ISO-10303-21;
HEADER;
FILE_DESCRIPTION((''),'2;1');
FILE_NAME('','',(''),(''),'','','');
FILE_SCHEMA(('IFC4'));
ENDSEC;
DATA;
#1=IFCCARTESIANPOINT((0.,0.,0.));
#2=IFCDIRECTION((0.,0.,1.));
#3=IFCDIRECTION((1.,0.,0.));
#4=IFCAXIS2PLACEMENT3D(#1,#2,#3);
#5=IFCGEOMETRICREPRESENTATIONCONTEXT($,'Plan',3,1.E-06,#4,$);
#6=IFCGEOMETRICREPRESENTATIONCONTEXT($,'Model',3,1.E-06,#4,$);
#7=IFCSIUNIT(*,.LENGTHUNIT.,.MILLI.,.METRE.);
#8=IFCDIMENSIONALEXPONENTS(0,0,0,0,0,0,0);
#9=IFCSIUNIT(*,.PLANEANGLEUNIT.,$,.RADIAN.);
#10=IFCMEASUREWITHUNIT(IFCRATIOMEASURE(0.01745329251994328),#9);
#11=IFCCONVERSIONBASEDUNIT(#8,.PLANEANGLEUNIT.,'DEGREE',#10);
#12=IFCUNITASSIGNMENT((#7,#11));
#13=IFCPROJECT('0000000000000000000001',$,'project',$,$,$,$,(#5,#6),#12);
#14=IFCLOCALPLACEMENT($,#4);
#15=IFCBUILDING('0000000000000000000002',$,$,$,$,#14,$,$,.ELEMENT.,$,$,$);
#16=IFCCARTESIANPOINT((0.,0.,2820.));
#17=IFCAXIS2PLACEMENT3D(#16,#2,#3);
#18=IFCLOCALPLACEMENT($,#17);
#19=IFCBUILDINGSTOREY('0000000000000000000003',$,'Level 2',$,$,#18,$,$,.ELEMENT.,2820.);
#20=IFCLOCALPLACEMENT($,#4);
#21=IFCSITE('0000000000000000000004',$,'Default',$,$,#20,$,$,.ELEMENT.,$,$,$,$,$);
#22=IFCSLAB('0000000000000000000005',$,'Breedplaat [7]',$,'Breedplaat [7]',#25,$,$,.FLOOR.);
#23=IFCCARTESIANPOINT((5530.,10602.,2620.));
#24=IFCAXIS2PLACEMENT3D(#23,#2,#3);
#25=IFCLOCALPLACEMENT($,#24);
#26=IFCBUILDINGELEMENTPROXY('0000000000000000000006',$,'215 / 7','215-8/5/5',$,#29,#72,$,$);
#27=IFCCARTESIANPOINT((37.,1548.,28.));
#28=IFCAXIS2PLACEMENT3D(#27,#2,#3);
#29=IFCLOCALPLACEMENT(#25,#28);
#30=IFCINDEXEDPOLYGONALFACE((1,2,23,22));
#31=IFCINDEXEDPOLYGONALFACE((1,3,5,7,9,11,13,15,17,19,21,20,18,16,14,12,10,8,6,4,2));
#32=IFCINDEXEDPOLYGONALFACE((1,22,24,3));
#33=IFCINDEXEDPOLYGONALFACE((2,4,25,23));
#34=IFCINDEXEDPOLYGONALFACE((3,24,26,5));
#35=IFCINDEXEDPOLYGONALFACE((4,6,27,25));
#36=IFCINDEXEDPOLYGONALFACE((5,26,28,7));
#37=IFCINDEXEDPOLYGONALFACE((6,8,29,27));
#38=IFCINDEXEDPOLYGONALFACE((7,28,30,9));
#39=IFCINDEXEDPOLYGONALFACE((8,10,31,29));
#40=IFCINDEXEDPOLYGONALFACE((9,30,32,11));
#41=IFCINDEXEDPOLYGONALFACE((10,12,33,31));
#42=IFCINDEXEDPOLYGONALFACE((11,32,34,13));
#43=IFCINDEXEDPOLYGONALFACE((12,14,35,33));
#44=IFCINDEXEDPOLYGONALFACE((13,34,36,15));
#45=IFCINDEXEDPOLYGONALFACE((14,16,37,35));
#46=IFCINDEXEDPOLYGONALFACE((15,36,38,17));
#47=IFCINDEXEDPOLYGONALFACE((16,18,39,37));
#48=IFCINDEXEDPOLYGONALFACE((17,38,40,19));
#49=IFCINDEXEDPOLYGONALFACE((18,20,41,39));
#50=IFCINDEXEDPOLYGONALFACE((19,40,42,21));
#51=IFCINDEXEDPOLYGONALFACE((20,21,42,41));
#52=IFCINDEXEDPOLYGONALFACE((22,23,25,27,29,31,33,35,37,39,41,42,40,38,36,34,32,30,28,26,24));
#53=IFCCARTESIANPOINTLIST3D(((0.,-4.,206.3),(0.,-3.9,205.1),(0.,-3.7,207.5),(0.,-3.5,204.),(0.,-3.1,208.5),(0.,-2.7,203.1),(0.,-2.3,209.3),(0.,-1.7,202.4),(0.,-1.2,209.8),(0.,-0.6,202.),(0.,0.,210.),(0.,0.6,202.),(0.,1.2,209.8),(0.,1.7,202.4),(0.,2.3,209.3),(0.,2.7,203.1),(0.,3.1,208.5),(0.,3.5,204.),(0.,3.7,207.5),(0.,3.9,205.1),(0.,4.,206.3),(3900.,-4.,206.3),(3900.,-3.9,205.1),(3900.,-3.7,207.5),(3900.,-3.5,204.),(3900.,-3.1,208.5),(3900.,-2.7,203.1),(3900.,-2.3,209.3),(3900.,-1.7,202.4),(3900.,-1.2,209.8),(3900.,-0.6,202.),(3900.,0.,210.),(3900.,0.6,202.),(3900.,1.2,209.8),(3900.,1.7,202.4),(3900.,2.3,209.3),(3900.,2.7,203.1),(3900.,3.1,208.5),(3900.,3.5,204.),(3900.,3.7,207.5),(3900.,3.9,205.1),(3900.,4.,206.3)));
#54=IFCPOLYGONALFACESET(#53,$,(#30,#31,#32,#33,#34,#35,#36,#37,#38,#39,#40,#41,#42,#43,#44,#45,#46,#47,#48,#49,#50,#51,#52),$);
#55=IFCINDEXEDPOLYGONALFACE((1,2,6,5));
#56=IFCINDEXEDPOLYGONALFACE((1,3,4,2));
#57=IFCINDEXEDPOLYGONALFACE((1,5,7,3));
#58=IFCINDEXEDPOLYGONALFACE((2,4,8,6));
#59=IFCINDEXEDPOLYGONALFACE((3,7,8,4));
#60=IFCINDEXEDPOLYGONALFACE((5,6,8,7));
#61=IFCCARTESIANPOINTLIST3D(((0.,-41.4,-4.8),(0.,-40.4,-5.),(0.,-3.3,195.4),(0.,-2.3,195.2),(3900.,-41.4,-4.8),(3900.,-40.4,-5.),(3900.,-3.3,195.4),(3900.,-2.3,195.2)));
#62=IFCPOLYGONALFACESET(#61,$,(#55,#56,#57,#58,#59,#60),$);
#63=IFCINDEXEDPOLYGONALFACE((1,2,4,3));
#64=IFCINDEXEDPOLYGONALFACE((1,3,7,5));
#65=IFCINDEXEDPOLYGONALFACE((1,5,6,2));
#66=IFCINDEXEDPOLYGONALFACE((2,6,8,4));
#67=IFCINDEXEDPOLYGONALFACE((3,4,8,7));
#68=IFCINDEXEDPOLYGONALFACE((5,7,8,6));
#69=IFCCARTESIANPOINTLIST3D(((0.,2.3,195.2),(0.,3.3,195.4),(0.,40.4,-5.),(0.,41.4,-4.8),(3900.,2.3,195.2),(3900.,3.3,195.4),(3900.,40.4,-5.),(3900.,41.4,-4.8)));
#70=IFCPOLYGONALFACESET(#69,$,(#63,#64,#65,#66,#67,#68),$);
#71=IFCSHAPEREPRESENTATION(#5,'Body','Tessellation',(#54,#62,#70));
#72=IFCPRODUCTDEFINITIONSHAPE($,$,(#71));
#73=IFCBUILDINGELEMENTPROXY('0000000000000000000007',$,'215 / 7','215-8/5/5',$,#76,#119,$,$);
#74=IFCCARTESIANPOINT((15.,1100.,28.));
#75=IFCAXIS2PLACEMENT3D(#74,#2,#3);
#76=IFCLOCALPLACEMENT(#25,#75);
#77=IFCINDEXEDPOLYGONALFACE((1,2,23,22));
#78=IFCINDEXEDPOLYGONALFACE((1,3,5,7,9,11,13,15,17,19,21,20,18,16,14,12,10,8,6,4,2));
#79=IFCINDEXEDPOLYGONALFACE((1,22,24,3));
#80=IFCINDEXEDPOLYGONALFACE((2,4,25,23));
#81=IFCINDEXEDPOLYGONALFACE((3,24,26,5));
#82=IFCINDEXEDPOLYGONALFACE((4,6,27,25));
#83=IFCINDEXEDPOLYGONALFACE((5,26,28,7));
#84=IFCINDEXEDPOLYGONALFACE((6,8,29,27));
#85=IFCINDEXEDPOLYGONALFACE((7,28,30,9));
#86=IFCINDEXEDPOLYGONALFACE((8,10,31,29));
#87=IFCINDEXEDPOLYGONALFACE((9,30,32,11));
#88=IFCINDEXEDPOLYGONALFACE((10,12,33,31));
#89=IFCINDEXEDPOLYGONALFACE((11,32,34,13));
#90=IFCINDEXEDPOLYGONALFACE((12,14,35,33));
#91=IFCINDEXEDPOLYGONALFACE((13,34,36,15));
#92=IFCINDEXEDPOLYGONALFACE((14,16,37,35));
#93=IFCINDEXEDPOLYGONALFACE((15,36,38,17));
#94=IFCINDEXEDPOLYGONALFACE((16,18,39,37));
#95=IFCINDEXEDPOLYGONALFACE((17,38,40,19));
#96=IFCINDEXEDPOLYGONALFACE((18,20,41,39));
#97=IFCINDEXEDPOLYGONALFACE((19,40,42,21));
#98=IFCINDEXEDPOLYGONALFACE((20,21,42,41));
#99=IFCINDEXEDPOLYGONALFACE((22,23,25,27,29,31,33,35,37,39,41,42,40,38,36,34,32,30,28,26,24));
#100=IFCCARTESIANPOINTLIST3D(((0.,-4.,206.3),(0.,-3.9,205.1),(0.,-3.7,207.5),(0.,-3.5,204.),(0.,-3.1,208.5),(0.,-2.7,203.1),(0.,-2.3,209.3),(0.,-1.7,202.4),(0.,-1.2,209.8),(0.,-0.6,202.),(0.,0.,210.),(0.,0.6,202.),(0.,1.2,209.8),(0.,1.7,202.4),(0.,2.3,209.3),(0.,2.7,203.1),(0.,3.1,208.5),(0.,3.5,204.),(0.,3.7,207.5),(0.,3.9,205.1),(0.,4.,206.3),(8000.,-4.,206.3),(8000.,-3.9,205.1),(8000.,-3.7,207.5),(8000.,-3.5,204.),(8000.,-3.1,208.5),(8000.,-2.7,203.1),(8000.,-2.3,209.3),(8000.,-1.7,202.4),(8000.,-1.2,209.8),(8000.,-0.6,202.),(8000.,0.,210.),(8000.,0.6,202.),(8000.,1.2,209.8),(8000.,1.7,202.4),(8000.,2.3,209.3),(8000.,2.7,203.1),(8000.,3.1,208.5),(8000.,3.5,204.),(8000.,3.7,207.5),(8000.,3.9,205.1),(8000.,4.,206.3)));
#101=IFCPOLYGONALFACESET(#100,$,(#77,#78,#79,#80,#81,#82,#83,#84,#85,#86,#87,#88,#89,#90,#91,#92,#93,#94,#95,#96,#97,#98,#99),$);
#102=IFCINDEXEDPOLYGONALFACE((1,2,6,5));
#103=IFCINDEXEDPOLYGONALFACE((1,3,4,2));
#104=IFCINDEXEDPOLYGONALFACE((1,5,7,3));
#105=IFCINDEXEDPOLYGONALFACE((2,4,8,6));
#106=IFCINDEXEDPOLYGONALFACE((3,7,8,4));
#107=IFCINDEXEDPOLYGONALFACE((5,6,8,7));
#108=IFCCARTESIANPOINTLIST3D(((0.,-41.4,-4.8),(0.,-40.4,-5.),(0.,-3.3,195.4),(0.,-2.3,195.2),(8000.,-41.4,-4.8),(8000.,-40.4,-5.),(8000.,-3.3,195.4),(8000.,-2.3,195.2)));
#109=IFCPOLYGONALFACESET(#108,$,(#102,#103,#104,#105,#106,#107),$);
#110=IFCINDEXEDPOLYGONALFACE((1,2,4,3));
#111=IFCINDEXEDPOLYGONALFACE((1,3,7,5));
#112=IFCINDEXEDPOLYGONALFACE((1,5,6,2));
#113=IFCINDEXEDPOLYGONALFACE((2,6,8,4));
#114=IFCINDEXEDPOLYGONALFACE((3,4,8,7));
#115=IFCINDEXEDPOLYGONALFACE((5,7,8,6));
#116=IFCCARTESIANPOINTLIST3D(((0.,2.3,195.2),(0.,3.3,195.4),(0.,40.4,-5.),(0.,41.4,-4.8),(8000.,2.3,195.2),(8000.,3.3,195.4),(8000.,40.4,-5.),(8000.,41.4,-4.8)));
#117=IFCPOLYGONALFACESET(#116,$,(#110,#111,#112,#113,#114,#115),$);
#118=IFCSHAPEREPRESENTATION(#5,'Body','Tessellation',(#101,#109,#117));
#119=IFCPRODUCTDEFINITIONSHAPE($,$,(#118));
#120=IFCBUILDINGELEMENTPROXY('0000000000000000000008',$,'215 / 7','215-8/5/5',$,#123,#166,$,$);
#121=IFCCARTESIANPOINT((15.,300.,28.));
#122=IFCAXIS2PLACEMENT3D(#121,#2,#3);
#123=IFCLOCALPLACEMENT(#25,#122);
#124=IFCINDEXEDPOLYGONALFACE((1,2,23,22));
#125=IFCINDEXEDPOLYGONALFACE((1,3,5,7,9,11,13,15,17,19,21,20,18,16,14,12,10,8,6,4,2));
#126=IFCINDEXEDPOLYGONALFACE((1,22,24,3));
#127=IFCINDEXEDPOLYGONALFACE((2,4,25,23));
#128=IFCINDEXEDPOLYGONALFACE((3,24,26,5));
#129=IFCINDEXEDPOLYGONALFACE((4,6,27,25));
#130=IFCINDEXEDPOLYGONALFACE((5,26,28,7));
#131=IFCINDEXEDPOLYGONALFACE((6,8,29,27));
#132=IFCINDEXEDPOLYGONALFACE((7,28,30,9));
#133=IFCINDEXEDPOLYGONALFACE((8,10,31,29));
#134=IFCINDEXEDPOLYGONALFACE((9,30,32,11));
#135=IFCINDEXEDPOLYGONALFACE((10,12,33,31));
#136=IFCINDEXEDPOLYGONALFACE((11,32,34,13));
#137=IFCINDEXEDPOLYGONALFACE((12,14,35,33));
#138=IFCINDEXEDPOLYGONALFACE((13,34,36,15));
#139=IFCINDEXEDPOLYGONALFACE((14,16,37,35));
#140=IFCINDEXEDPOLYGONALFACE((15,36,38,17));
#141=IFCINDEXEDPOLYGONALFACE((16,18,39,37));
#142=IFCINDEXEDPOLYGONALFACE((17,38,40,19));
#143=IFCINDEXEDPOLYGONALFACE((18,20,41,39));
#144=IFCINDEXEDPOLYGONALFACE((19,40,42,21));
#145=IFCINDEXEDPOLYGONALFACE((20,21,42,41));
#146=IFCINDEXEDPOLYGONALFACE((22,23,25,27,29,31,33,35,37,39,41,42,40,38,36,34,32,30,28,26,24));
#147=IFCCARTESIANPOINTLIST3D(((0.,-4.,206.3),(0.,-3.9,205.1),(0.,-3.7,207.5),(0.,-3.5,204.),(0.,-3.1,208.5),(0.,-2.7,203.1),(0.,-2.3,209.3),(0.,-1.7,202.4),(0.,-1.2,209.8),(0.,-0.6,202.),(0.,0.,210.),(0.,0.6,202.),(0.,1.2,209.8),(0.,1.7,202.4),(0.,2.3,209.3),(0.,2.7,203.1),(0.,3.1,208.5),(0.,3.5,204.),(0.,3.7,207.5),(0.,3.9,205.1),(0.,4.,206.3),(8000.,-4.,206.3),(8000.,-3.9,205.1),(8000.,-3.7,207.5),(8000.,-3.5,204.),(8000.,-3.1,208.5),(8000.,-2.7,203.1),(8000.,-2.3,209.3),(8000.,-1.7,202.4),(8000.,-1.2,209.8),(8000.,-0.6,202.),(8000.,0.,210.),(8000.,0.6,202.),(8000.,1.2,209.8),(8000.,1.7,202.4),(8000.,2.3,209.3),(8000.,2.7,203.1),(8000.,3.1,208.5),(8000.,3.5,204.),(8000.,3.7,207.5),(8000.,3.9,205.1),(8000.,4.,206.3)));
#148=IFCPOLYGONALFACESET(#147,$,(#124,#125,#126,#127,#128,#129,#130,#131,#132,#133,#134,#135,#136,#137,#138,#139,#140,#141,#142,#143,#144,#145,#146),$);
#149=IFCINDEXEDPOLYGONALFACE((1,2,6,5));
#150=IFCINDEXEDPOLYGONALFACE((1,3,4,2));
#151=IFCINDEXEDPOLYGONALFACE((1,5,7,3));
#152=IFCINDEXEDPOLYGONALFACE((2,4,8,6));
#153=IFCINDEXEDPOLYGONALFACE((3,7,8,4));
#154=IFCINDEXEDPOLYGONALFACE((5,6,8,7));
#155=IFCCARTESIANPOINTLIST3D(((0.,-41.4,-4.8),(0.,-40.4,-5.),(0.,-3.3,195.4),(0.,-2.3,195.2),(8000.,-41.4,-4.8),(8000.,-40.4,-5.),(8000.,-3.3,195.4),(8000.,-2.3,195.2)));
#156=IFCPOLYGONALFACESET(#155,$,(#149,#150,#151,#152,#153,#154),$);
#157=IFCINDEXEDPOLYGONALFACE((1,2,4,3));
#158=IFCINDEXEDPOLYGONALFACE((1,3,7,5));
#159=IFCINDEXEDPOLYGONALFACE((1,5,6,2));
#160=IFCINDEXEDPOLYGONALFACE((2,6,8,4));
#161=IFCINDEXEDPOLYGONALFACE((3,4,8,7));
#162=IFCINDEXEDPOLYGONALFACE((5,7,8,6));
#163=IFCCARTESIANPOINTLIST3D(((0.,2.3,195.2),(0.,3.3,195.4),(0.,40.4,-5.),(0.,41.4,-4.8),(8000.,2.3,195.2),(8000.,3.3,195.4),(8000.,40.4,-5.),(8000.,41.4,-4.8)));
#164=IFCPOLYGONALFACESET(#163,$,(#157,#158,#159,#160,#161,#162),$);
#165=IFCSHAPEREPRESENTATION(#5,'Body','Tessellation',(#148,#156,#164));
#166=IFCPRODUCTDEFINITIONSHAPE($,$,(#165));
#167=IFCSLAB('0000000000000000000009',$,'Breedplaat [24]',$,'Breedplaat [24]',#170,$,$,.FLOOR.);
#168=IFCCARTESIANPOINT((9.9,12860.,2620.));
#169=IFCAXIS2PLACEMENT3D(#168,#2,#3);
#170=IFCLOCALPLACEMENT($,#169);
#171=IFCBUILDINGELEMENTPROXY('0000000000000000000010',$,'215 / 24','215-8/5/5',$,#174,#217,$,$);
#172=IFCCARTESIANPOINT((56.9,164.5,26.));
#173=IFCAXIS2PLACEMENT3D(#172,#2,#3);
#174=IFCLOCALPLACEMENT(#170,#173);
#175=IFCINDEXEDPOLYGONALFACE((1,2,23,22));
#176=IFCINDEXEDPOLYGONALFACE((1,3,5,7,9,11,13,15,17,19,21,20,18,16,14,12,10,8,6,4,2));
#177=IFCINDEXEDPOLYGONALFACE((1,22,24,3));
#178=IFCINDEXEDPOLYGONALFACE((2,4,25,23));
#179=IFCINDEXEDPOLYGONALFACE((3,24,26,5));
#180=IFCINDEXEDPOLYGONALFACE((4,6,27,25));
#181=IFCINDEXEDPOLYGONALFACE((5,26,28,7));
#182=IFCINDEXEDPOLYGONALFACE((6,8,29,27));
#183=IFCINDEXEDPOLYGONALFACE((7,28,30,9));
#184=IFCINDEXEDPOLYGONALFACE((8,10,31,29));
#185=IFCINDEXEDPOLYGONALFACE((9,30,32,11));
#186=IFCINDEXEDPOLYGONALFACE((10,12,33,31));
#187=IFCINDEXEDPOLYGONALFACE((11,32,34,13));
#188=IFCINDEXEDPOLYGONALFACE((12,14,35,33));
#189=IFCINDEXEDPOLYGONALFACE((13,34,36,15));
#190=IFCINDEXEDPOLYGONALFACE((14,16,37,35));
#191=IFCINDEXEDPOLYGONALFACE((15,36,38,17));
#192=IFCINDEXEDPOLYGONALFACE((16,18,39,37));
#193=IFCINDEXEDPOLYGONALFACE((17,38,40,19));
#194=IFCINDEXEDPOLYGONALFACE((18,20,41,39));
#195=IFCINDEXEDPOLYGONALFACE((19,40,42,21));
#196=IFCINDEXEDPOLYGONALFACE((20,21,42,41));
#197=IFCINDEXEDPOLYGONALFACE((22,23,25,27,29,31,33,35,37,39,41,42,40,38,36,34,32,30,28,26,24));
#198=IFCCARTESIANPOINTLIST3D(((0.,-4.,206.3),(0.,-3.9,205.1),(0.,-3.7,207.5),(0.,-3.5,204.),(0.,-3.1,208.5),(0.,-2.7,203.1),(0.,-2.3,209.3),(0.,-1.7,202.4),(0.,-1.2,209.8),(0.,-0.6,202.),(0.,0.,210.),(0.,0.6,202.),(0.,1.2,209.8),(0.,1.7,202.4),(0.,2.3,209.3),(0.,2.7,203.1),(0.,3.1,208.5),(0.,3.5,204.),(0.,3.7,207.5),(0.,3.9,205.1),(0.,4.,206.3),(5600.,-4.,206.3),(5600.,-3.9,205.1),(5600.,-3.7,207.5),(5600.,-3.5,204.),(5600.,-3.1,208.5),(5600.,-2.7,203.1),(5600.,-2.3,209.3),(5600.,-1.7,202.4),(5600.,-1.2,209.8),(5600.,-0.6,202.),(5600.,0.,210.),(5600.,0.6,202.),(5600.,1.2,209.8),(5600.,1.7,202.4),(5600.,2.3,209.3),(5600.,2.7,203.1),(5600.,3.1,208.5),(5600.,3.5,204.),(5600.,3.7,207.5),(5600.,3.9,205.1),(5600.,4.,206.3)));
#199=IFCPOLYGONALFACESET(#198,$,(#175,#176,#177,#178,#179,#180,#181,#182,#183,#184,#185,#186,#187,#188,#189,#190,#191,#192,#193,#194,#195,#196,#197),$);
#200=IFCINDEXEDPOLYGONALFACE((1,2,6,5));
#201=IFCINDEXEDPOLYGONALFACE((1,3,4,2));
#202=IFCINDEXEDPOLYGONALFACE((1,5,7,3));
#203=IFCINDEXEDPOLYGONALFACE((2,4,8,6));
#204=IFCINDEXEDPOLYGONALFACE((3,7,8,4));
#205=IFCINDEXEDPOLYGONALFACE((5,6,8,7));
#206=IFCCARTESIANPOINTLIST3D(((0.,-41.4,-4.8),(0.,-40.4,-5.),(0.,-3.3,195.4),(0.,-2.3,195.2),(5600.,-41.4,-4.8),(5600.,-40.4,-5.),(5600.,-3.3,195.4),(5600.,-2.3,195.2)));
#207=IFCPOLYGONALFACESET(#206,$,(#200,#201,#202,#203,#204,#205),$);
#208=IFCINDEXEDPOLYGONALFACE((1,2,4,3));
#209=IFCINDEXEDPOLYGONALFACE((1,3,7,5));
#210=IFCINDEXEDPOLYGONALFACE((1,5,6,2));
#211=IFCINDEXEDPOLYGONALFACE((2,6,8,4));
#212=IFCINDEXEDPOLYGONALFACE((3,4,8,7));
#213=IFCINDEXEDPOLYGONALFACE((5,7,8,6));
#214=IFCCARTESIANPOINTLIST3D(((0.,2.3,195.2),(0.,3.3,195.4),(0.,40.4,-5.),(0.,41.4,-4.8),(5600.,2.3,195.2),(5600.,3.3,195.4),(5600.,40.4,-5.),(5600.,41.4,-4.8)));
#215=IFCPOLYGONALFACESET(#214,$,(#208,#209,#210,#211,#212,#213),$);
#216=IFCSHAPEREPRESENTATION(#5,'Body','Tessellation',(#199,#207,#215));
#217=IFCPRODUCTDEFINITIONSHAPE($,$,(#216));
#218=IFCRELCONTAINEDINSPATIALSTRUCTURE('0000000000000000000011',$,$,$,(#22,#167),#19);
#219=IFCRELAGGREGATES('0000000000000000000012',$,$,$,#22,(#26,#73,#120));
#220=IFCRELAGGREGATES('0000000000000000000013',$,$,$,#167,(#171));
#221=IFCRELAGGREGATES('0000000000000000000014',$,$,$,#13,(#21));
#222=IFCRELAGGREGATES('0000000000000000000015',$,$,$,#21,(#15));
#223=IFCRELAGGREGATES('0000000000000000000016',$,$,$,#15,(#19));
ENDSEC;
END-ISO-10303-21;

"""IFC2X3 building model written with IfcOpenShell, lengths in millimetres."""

from ifc_helpers import new_model, entity, si_unit, converted_unit, frame, origin_with_axes, origin_2d_with_axis, place, context, project, spatial, rectangle, circle, extrude, element, aggregate, save


model = new_model("IFC2X3")

# Units and contexts
plan_context = context("Plan", 3, precision=1e-06, world=origin_with_axes())
model_context = context("Model", 3, precision=1e-06, world=origin_with_axes())
ifc_project = project(units=[si_unit("LENGTHUNIT", "METRE", prefix="MILLI"), converted_unit("PLANEANGLEUNIT", "DEGREE", entity("IfcRatioMeasure", 0.01745329251994328), si_unit("PLANEANGLEUNIT", "RADIAN"), dimensions=[0, 0, 0, 0, 0, 0, 0])], contexts=[plan_context, model_context])

# Site, building, storey
site_placement = place(None, origin_with_axes())
site = spatial("IfcSite", under=ifc_project, at=site_placement, Name="Default", CompositionType="ELEMENT")
building_placement = place(None, origin_with_axes())
building = spatial("IfcBuilding", under=site, at=building_placement, CompositionType="ELEMENT")
storey_placement = place(None, frame((0.0, 0.0, 2820.0), z_axis=(0.0, 0.0, 1.0), x_axis=(1.0, 0.0, 0.0)))
storey = spatial("IfcBuildingStorey", under=building, at=storey_placement, Name="Level 2", CompositionType="ELEMENT", Elevation=2820.0)

# Slab, building element proxies
slab_1_placement = place(None, frame((5530.0, 10602.0, 2620.0), z_axis=(0.0, 0.0, 1.0), x_axis=(1.0, 0.0, 0.0)))
slab_1 = element("IfcSlab", 1, at=slab_1_placement, inside=storey, Name="Breedplaat [7]", ObjectType="Breedplaat [7]", PredefinedType="FLOOR")
proxy_1_placement = place(slab_1_placement, frame((37.0, 1548.0, 28.0), z_axis=(0.0, 0.0, 1.0), x_axis=(1.0, 0.0, 0.0)))
proxy_1 = element("IfcBuildingElementProxy", 2, at=proxy_1_placement, Name="215 / 7", Description="215-8/5/5", context=plan_context, shape_type="SweptSolid", body=[
    extrude(circle(Radius=4.0, at=origin_2d_with_axis()), frame((0.0, 0.0, 206.0), z_axis=(1.0, 0.0, 0.0), x_axis=(0.0, 0.0, 1.0)), (0.0, 0.0, 1.0), 3900.0),
    extrude(rectangle(XDim=203.8, YDim=1.0, at=origin_2d_with_axis()), frame((0.0, -21.9, 95.2), z_axis=(1.0, 0.0, 0.0), x_axis=(0.0, 0.187112, 0.982339)), (0.0, 0.0, 1.0), 3900.0),
    extrude(rectangle(XDim=203.8, YDim=1.0, at=origin_2d_with_axis()), frame((0.0, 21.9, 95.2), z_axis=(1.0, 0.0, 0.0), x_axis=(0.0, -0.187112, 0.982339)), (0.0, 0.0, 1.0), 3900.0),
])
proxy_2_placement = place(slab_1_placement, frame((15.0, 1100.0, 28.0), z_axis=(0.0, 0.0, 1.0), x_axis=(1.0, 0.0, 0.0)))
proxy_2 = element("IfcBuildingElementProxy", 3, at=proxy_2_placement, Name="215 / 7", Description="215-8/5/5", context=plan_context, shape_type="SweptSolid", body=[
    extrude(circle(Radius=4.0, at=origin_2d_with_axis()), frame((0.0, 0.0, 206.0), z_axis=(1.0, 0.0, 0.0), x_axis=(0.0, 0.0, 1.0)), (0.0, 0.0, 1.0), 8000.0),
    extrude(rectangle(XDim=203.8, YDim=1.0, at=origin_2d_with_axis()), frame((0.0, -21.9, 95.2), z_axis=(1.0, 0.0, 0.0), x_axis=(0.0, 0.187112, 0.982339)), (0.0, 0.0, 1.0), 8000.0),
    extrude(rectangle(XDim=203.8, YDim=1.0, at=origin_2d_with_axis()), frame((0.0, 21.9, 95.2), z_axis=(1.0, 0.0, 0.0), x_axis=(0.0, -0.187112, 0.982339)), (0.0, 0.0, 1.0), 8000.0),
])
proxy_3_placement = place(slab_1_placement, frame((15.0, 300.0, 28.0), z_axis=(0.0, 0.0, 1.0), x_axis=(1.0, 0.0, 0.0)))
proxy_3 = element("IfcBuildingElementProxy", 4, at=proxy_3_placement, Name="215 / 7", Description="215-8/5/5", context=plan_context, shape_type="SweptSolid", body=[
    extrude(circle(Radius=4.0, at=origin_2d_with_axis()), frame((0.0, 0.0, 206.0), z_axis=(1.0, 0.0, 0.0), x_axis=(0.0, 0.0, 1.0)), (0.0, 0.0, 1.0), 8000.0),
    extrude(rectangle(XDim=203.8, YDim=1.0, at=origin_2d_with_axis()), frame((0.0, -21.9, 95.2), z_axis=(1.0, 0.0, 0.0), x_axis=(0.0, 0.187112, 0.982339)), (0.0, 0.0, 1.0), 8000.0),
    extrude(rectangle(XDim=203.8, YDim=1.0, at=origin_2d_with_axis()), frame((0.0, 21.9, 95.2), z_axis=(1.0, 0.0, 0.0), x_axis=(0.0, -0.187112, 0.982339)), (0.0, 0.0, 1.0), 8000.0),
])
aggregate(slab_1, [proxy_1, proxy_2, proxy_3])

# Slab, building element proxy
slab_2_placement = place(None, frame((9.9, 12860.0, 2620.0), z_axis=(0.0, 0.0, 1.0), x_axis=(1.0, 0.0, 0.0)))
slab_2 = element("IfcSlab", 5, at=slab_2_placement, inside=storey, Name="Breedplaat [24]", ObjectType="Breedplaat [24]", PredefinedType="FLOOR")
proxy_4_placement = place(slab_2_placement, frame((56.9, 164.5, 26.0), z_axis=(0.0, 0.0, 1.0), x_axis=(1.0, 0.0, 0.0)))
proxy_4 = element("IfcBuildingElementProxy", 6, at=proxy_4_placement, Name="215 / 24", Description="215-8/5/5", context=plan_context, shape_type="SweptSolid", body=[
    extrude(circle(Radius=4.0, at=origin_2d_with_axis()), frame((0.0, 0.0, 206.0), z_axis=(1.0, 0.0, 0.0), x_axis=(0.0, 0.0, 1.0)), (0.0, 0.0, 1.0), 5600.0),
    extrude(rectangle(XDim=203.8, YDim=1.0, at=origin_2d_with_axis()), frame((0.0, -21.9, 95.2), z_axis=(1.0, 0.0, 0.0), x_axis=(0.0, 0.187112, 0.982339)), (0.0, 0.0, 1.0), 5600.0),
    extrude(rectangle(XDim=203.8, YDim=1.0, at=origin_2d_with_axis()), frame((0.0, 21.9, 95.2), z_axis=(1.0, 0.0, 0.0), x_axis=(0.0, -0.187112, 0.982339)), (0.0, 0.0, 1.0), 5600.0),
])
aggregate(slab_2, [proxy_4])

save(model, "model.ifc")
